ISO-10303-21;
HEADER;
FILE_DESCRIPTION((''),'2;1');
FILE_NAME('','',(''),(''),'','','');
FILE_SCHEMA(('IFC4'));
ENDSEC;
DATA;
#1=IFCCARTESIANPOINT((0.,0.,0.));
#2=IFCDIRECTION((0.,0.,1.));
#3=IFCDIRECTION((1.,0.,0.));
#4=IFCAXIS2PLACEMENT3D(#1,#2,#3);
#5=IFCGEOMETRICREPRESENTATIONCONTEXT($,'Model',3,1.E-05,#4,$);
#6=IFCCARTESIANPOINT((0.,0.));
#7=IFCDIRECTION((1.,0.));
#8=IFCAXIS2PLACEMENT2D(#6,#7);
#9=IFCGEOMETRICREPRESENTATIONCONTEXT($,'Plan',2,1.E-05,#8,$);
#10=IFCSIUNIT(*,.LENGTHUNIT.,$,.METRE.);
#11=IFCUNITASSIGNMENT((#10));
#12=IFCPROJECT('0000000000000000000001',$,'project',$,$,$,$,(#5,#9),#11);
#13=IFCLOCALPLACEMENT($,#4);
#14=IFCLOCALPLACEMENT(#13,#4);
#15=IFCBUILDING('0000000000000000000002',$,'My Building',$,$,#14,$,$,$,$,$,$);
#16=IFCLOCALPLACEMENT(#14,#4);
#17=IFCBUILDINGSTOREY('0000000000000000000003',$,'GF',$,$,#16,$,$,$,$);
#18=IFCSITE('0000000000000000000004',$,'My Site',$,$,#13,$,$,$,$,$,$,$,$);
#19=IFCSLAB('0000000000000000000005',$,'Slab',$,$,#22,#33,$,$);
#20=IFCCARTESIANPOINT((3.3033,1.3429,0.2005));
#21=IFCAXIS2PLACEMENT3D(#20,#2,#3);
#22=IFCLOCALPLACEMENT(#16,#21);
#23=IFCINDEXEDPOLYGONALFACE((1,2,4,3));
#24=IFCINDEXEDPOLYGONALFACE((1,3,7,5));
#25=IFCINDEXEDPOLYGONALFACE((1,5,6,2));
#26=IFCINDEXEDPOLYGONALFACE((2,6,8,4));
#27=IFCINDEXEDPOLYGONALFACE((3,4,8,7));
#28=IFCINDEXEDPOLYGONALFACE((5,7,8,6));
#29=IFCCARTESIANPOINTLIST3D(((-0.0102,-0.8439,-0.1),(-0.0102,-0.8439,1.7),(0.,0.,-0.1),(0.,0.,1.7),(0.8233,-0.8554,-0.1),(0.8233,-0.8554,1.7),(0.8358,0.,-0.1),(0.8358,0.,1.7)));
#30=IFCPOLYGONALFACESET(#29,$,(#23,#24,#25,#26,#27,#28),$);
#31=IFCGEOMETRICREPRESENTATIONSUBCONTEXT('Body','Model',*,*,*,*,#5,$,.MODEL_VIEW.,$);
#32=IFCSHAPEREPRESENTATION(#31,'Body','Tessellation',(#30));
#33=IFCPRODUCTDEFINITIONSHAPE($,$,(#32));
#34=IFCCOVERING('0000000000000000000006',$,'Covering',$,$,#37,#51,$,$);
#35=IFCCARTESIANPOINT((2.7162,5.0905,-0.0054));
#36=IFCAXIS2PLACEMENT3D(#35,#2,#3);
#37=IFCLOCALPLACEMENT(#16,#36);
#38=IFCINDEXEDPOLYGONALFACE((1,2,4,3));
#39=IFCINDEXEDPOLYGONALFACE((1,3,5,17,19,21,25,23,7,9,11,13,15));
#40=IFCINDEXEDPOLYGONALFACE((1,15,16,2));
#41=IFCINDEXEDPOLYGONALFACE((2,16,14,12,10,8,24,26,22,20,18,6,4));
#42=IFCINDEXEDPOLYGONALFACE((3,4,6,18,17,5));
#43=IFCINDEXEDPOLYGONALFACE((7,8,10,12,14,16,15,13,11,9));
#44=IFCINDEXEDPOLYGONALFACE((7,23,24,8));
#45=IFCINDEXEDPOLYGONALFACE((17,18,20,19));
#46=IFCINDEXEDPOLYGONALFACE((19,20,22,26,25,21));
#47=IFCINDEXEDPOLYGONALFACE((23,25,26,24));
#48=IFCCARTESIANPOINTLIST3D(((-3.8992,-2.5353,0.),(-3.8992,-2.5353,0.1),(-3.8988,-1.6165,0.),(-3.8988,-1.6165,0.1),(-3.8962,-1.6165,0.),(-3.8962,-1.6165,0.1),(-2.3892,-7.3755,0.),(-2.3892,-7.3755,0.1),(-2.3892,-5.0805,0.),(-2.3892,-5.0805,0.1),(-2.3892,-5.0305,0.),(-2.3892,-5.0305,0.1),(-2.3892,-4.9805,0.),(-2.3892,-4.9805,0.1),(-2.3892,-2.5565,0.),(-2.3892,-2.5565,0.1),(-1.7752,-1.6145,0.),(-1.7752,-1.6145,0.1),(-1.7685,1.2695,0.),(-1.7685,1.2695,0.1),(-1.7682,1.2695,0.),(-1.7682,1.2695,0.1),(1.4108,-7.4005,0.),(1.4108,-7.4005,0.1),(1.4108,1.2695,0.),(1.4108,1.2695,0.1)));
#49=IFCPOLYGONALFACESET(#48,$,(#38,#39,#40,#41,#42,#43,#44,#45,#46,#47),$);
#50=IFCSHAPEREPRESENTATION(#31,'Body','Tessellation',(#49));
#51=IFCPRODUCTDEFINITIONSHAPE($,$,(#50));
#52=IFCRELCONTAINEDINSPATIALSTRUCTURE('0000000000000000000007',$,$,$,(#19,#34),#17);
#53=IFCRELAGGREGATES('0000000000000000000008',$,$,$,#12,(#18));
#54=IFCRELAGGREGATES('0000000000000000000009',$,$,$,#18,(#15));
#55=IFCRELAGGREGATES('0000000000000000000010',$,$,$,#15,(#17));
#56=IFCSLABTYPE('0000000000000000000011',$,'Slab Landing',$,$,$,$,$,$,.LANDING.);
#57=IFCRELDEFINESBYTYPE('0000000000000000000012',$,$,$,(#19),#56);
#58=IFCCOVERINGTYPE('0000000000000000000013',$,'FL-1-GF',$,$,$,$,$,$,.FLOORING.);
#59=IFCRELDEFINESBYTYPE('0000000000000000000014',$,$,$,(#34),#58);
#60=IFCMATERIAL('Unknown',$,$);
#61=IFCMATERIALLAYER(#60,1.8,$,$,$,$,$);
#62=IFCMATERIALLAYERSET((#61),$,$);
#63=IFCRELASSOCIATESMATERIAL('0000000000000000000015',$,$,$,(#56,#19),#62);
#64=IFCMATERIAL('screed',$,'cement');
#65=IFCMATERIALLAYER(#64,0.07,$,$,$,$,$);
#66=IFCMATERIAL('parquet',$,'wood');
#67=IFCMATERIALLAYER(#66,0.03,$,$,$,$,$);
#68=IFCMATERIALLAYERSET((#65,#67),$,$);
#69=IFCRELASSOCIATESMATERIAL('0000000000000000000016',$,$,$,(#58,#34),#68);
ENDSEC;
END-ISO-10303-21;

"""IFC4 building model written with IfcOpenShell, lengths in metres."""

from ifc_helpers import new_model, si_unit, frame, origin_with_axes, origin_2d_with_axis, place, context, subcontext, project, spatial, line, indexed_curve, outline, extrude, material, layer, layer_set, layer_usage, type_object, element, save


model = new_model("IFC4")

# Units and contexts
model_context = context("Model", 3, precision=1e-05, world=origin_with_axes())
plan_context = context("Plan", 2, precision=1e-05, world=origin_2d_with_axis())
body_context_1 = subcontext(model_context, "Body", "Model", "MODEL_VIEW")
ifc_project = project(units=[si_unit("LENGTHUNIT", "METRE")], contexts=[model_context, plan_context])

# Site, building, storey
site_placement = place(None, origin_with_axes())
site = spatial("IfcSite", under=ifc_project, at=site_placement, Name="My Site")
building_placement = place(site_placement, origin_with_axes())
building = spatial("IfcBuilding", under=site, at=building_placement, Name="My Building")
storey_placement = place(building_placement, origin_with_axes())
storey = spatial("IfcBuildingStorey", under=building, at=storey_placement, Name="GF")

# Slab
ifc_material_1 = material(Name="Unknown")
ifc_layer_1 = layer(ifc_material_1, 1.8)
ifc_layer_set_1 = layer_set([ifc_layer_1])
ifc_layer_usage_1 = layer_usage(ifc_layer_set_1, "AXIS3", "POSITIVE", -0.1)
slab_type_1 = type_object("IfcSlabType", Name="Slab Landing", PredefinedType="LANDING", material=ifc_layer_set_1)
slab_1_placement = place(storey_placement, frame((3.3033, 1.3429, 0.2005), z_axis=(0.0, 0.0, 1.0), x_axis=(1.0, 0.0, 0.0)))
element("IfcSlab", 1, at=slab_1_placement, inside=storey, type_object=slab_type_1, material=ifc_layer_usage_1, Name="Slab", context=body_context_1, shape_type="SweptSolid", body=[
    extrude(outline(indexed_curve([(0.0, 0.0), (-0.0102, -0.8439), (0.8233, -0.8554), (0.8358, 0.0), (0.0, 0.0)])), frame((0.0, 0.0, -0.1), z_axis=(0.0, 0.0, 1.0), x_axis=(1.0, 0.0, 0.0)), (0.0, 0.0, 1.0), 1.8),
])

# Covering
ifc_material_2 = material(Name="screed", Category="cement")
ifc_layer_2 = layer(ifc_material_2, 0.07)
ifc_material_3 = material(Name="parquet", Category="wood")
ifc_layer_3 = layer(ifc_material_3, 0.03)
ifc_layer_set_2 = layer_set([ifc_layer_2, ifc_layer_3])
ifc_layer_usage_2 = layer_usage(ifc_layer_set_2, "AXIS3", "POSITIVE", 0.0)
covering_type = type_object("IfcCoveringType", Name="FL-1-GF", PredefinedType="FLOORING", material=ifc_layer_set_2)
covering_placement = place(storey_placement, frame((2.7162, 5.0905, -0.0054), z_axis=(0.0, 0.0, 1.0), x_axis=(1.0, 0.0, 0.0)))
element("IfcCovering", 2, at=covering_placement, inside=storey, type_object=covering_type, material=ifc_layer_usage_2, Name="Covering", context=body_context_1, shape_type="SweptSolid", body=[
    extrude(outline(indexed_curve([(-2.3892, -7.3755), (-2.3892, -5.0805), (-2.3892, -5.0305), (-2.3892, -5.0305), (-2.3892, -4.9805), (-2.3892, -2.5565), (-2.3892, -2.5565), (-3.8992, -2.5353), (-3.8988, -1.6165), (-3.8962, -1.6165), (-1.7752, -1.6145), (-1.7752, -1.6145), (-1.7685, 1.2695), (-1.7682, 1.2695), (1.4108, 1.2695), (1.4108, -7.4005)], segments=[line(1, 2, 3, 4, 5, 6, 7, 8, 9, 10, 11, 12, 13, 14, 15, 16, 1)])), origin_with_axes(), (0.0, 0.0, 1.0), 0.1),
])

save(model, "model.ifc")
